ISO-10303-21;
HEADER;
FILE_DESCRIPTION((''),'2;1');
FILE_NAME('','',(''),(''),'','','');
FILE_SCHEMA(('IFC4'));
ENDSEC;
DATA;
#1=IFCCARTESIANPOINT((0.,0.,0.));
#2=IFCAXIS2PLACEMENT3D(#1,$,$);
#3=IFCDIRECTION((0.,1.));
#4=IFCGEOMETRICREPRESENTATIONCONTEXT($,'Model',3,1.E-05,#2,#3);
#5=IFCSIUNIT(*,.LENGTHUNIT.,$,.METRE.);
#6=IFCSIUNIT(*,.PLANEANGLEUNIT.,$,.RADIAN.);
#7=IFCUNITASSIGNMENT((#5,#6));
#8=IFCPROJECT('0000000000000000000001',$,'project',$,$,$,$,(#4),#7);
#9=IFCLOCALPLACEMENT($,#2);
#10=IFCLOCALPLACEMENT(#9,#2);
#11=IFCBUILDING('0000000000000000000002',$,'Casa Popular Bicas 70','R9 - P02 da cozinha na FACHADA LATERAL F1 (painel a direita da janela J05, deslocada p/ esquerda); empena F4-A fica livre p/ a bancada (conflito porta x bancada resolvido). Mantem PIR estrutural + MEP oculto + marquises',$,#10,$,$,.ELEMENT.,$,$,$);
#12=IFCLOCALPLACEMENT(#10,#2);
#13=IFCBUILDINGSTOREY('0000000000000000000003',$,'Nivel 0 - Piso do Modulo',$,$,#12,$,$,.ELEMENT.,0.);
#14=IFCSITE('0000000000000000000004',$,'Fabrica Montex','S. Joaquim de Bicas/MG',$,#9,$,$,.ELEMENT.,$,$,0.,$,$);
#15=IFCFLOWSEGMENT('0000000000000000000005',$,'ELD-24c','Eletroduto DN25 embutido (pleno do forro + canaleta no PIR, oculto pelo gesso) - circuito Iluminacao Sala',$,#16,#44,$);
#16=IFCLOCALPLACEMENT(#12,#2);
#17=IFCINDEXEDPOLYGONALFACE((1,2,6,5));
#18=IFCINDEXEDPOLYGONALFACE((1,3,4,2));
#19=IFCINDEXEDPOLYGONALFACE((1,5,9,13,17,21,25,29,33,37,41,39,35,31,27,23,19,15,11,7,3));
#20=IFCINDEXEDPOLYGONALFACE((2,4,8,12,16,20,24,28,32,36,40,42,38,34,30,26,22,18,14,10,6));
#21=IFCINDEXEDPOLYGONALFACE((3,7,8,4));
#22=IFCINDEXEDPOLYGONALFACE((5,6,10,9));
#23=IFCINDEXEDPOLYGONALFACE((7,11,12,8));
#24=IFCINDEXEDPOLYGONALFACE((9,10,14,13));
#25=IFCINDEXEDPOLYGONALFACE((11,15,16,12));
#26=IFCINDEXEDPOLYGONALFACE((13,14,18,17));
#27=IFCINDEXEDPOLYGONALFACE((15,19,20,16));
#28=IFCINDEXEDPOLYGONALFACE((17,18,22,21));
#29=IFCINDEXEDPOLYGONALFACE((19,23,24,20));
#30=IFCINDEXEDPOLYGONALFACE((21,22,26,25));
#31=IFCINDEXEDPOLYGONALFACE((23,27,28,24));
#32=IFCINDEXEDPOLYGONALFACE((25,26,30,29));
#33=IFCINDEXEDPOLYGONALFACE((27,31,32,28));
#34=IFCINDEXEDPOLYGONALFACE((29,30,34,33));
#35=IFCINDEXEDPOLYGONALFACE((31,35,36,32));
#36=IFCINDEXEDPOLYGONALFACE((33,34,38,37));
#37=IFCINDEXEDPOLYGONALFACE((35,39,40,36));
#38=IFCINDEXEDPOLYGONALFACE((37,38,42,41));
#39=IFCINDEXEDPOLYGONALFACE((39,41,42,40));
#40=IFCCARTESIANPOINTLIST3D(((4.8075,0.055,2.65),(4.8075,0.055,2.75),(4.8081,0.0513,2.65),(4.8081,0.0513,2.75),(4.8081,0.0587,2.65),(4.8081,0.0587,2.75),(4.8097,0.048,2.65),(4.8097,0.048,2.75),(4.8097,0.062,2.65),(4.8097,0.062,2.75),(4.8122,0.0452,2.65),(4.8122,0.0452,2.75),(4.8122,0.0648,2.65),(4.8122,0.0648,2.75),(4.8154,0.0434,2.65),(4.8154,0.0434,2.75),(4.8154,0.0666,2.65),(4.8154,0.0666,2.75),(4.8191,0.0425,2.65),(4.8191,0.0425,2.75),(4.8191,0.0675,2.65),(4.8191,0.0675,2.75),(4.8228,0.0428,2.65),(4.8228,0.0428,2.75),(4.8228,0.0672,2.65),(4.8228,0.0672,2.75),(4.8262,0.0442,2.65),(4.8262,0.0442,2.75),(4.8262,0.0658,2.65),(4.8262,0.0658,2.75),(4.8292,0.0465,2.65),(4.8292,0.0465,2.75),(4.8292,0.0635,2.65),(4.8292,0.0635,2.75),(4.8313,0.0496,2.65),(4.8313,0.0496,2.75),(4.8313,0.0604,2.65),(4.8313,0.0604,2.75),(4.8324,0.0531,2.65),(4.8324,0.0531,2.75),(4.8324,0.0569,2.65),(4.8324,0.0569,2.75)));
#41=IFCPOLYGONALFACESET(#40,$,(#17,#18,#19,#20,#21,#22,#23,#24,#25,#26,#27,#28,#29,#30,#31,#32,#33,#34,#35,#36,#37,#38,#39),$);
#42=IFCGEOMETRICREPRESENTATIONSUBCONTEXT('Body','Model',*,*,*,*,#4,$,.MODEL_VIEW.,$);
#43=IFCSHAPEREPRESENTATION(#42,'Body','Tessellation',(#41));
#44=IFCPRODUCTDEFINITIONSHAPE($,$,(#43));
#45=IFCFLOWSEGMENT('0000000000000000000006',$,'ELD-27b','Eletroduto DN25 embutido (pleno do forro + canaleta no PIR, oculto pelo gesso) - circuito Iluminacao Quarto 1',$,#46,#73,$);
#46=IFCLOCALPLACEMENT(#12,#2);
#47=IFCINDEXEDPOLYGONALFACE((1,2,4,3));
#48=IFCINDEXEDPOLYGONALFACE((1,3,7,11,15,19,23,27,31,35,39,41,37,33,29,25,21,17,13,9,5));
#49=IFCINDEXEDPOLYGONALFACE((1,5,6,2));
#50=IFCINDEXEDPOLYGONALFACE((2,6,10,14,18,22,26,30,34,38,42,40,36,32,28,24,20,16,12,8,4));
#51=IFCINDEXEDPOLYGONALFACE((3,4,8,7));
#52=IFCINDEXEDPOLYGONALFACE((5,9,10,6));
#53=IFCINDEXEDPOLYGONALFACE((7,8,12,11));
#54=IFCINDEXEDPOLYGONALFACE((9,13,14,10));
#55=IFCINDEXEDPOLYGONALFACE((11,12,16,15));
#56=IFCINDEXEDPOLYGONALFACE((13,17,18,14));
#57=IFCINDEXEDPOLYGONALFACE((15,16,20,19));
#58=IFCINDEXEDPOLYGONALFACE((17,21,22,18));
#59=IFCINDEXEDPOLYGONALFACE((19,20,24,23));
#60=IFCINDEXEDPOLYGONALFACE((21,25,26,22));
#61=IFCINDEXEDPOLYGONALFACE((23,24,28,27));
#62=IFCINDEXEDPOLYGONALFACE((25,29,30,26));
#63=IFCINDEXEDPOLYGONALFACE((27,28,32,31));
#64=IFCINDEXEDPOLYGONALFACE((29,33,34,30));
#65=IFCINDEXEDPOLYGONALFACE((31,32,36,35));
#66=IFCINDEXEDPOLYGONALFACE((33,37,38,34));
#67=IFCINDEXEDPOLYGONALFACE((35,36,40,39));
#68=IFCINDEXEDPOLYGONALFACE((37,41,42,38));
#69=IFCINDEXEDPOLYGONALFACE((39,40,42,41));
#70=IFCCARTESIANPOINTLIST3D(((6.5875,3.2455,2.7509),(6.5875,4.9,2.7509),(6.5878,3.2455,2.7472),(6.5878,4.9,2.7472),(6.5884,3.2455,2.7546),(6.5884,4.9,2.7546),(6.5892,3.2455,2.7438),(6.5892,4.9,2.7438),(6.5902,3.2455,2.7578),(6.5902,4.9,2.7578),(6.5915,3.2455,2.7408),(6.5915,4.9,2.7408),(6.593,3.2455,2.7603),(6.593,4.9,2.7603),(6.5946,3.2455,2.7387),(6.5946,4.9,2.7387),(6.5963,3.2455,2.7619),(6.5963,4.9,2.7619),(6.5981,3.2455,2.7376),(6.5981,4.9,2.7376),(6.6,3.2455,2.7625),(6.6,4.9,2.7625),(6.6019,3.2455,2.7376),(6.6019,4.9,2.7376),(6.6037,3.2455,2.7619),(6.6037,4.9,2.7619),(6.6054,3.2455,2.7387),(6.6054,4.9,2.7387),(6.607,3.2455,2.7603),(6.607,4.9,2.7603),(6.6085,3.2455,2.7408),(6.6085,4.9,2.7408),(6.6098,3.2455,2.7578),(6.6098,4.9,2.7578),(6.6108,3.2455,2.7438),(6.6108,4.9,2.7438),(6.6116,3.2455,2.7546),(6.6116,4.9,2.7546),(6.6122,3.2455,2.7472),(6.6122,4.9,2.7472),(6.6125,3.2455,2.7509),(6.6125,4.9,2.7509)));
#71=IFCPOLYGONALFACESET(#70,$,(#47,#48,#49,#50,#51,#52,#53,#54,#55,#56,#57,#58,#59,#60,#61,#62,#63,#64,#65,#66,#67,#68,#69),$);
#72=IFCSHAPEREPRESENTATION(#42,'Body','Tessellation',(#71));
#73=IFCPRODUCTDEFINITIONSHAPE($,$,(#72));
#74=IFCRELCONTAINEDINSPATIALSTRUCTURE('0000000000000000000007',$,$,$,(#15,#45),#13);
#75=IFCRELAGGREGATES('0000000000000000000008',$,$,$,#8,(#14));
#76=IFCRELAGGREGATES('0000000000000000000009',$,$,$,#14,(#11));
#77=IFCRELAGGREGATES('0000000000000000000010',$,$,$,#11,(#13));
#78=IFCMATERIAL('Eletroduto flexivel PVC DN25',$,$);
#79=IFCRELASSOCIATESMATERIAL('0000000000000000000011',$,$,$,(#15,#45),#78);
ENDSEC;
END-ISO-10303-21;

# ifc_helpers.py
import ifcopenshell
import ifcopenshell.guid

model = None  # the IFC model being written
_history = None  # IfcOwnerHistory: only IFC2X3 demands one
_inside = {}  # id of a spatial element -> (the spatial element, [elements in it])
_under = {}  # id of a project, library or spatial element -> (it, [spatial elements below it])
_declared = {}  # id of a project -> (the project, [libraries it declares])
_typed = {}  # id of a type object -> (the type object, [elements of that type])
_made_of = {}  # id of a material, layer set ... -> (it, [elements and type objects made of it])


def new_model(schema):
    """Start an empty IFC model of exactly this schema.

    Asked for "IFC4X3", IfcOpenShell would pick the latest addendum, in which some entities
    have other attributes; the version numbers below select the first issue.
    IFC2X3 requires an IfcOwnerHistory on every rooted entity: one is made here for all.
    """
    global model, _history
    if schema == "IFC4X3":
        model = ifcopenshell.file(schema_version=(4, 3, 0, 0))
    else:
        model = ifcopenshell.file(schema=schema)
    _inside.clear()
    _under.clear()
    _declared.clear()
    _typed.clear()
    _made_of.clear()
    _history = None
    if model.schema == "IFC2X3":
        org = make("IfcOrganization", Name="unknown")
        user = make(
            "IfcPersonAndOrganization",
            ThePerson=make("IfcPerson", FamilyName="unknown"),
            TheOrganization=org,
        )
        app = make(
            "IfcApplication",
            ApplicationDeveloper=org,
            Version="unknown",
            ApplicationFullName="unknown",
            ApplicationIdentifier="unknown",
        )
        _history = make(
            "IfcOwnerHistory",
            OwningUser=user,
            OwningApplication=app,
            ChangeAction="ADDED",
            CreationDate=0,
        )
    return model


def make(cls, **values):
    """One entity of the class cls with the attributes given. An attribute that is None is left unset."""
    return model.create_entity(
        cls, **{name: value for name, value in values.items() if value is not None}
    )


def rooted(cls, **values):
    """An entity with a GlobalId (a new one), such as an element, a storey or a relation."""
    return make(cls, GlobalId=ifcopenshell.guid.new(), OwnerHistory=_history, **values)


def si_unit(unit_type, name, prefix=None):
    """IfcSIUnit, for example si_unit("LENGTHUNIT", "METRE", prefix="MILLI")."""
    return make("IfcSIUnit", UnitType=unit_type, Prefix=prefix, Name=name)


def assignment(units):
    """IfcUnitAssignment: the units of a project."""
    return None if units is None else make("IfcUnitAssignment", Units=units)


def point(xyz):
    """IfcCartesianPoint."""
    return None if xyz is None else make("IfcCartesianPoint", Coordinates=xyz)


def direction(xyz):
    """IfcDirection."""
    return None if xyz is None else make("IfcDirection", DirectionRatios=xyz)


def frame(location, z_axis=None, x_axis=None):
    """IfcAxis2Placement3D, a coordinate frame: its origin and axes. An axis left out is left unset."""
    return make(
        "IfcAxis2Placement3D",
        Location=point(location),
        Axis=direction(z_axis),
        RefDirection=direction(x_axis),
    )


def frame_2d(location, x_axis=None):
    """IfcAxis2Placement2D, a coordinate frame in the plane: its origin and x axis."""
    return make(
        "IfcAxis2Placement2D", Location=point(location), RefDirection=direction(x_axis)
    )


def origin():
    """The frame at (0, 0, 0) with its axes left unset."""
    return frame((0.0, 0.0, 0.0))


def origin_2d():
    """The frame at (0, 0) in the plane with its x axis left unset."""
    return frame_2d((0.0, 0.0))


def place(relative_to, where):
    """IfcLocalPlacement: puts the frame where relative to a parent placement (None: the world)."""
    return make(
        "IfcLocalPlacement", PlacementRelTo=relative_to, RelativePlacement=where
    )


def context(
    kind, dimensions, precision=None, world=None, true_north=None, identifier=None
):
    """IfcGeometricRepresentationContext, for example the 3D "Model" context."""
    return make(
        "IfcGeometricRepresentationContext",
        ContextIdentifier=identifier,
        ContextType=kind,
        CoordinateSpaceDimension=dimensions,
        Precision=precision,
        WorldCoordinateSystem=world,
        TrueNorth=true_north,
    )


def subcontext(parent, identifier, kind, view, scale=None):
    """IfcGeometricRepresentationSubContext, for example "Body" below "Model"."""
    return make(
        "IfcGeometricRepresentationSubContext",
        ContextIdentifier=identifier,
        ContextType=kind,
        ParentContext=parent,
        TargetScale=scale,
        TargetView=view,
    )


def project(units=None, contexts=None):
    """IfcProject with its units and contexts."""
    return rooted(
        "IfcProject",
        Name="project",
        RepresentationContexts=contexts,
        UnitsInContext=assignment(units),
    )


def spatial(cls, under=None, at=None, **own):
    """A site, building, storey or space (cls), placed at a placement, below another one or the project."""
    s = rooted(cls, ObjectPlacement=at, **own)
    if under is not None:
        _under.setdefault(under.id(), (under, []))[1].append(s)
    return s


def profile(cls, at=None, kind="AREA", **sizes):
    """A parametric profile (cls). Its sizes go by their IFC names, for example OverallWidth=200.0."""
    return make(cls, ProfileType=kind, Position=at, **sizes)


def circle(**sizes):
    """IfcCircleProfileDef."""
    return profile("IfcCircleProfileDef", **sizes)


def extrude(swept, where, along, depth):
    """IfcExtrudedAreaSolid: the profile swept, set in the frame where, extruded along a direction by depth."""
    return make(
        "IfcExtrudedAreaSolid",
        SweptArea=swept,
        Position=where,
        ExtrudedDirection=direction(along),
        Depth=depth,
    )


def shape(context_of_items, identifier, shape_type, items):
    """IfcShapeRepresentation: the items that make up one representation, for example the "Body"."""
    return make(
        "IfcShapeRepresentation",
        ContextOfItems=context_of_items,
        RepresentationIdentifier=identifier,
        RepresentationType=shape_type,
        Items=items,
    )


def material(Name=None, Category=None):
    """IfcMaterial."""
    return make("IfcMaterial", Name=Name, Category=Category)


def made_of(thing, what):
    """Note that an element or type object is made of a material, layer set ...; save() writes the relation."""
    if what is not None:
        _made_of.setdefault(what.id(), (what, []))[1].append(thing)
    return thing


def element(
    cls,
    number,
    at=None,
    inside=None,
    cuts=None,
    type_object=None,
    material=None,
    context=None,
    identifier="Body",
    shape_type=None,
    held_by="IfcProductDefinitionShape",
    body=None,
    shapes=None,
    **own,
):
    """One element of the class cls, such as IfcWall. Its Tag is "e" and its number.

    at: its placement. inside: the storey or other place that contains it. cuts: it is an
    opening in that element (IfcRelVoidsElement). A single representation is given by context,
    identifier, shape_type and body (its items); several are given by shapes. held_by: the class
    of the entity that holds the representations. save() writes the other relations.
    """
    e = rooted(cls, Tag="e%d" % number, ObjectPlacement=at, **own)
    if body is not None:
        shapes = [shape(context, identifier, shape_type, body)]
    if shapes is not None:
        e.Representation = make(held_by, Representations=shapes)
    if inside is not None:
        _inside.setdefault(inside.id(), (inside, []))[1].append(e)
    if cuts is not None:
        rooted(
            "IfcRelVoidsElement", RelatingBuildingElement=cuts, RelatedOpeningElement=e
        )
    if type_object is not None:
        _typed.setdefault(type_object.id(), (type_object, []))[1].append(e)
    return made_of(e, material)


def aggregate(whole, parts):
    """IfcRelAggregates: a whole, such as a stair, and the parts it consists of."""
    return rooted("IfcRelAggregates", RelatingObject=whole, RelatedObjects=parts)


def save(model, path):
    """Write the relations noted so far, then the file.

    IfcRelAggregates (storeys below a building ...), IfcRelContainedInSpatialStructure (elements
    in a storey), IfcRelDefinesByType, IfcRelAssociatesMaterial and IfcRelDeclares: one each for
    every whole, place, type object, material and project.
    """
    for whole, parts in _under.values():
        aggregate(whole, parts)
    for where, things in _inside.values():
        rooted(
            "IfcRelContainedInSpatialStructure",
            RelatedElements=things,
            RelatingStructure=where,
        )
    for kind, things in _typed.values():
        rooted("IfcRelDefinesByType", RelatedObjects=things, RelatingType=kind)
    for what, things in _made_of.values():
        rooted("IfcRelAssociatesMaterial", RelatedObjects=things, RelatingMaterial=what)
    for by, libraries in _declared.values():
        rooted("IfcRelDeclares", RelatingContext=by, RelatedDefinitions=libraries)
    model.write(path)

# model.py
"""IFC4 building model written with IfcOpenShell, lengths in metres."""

from ifc_helpers import new_model, si_unit, direction, frame, origin, origin_2d, place, context, subcontext, project, spatial, circle, extrude, material, element, save


model = new_model("IFC4")

# Units and contexts
model_context = context("Model", 3, precision=1e-05, world=origin(), true_north=direction((0.0, 1.0)))
body_context = subcontext(model_context, "Body", "Model", "MODEL_VIEW")
ifc_project = project(units=[si_unit("LENGTHUNIT", "METRE"), si_unit("PLANEANGLEUNIT", "RADIAN")], contexts=[model_context])

# Site, building, storey
site_placement = place(None, origin())
site = spatial("IfcSite", under=ifc_project, at=site_placement, Name="Fabrica Montex", Description="S. Joaquim de Bicas/MG", CompositionType="ELEMENT", RefElevation=0.0)
building_placement = place(site_placement, origin())
building = spatial("IfcBuilding", under=site, at=building_placement, Name="Casa Popular Bicas 70", Description="R9 - P02 da cozinha na FACHADA LATERAL F1 (painel a direita da janela J05, deslocada p/ esquerda); empena F4-A fica livre p/ a bancada (conflito porta x bancada resolvido). Mantem PIR estrutural + MEP oculto + marquises", CompositionType="ELEMENT")
storey_placement = place(building_placement, origin())
storey = spatial("IfcBuildingStorey", under=building, at=storey_placement, Name="Nivel 0 - Piso do Modulo", CompositionType="ELEMENT", Elevation=0.0)

# Shared definitions
ifc_material_1 = material(Name="Eletroduto flexivel PVC DN25")

# Flow segments
flow_segment_1_placement = place(None, frame((4.82, 0.055, 2.75), z_axis=(0.0, 0.0, -1.0), x_axis=(-1.0, 0.0, 0.0)))
element("IfcFlowSegment", 1, at=flow_segment_1_placement, inside=storey, material=ifc_material_1, Name="ELD-24c", Description="Eletroduto DN25 embutido (pleno do forro + canaleta no PIR, oculto pelo gesso) - circuito Iluminacao Sala", context=body_context, shape_type="SweptSolid", body=[
    extrude(circle(Radius=0.0125, at=origin_2d()), origin(), (0.0, 0.0, 1.0), 0.1),
])
for number, where, z_axis, x_axis, name in (
    (2, (6.6, 3.2455, 2.75), (0.0, 1.0, 0.0), (0.0, 0.0, 1.0), "ELD-27b"),
):
    element("IfcFlowSegment", number, at=place(storey_placement, frame(where, z_axis=z_axis, x_axis=x_axis)), inside=storey, material=ifc_material_1, Name=name, Description="Eletroduto DN25 embutido (pleno do forro + canaleta no PIR, oculto pelo gesso) - circuito Iluminacao Quarto 1", context=body_context, shape_type="SweptSolid", body=[
        extrude(circle(Radius=0.0125, at=origin_2d()), origin(), (0.0, 0.0, 1.0), 1.6545),
    ])

save(model, "model.ifc")
